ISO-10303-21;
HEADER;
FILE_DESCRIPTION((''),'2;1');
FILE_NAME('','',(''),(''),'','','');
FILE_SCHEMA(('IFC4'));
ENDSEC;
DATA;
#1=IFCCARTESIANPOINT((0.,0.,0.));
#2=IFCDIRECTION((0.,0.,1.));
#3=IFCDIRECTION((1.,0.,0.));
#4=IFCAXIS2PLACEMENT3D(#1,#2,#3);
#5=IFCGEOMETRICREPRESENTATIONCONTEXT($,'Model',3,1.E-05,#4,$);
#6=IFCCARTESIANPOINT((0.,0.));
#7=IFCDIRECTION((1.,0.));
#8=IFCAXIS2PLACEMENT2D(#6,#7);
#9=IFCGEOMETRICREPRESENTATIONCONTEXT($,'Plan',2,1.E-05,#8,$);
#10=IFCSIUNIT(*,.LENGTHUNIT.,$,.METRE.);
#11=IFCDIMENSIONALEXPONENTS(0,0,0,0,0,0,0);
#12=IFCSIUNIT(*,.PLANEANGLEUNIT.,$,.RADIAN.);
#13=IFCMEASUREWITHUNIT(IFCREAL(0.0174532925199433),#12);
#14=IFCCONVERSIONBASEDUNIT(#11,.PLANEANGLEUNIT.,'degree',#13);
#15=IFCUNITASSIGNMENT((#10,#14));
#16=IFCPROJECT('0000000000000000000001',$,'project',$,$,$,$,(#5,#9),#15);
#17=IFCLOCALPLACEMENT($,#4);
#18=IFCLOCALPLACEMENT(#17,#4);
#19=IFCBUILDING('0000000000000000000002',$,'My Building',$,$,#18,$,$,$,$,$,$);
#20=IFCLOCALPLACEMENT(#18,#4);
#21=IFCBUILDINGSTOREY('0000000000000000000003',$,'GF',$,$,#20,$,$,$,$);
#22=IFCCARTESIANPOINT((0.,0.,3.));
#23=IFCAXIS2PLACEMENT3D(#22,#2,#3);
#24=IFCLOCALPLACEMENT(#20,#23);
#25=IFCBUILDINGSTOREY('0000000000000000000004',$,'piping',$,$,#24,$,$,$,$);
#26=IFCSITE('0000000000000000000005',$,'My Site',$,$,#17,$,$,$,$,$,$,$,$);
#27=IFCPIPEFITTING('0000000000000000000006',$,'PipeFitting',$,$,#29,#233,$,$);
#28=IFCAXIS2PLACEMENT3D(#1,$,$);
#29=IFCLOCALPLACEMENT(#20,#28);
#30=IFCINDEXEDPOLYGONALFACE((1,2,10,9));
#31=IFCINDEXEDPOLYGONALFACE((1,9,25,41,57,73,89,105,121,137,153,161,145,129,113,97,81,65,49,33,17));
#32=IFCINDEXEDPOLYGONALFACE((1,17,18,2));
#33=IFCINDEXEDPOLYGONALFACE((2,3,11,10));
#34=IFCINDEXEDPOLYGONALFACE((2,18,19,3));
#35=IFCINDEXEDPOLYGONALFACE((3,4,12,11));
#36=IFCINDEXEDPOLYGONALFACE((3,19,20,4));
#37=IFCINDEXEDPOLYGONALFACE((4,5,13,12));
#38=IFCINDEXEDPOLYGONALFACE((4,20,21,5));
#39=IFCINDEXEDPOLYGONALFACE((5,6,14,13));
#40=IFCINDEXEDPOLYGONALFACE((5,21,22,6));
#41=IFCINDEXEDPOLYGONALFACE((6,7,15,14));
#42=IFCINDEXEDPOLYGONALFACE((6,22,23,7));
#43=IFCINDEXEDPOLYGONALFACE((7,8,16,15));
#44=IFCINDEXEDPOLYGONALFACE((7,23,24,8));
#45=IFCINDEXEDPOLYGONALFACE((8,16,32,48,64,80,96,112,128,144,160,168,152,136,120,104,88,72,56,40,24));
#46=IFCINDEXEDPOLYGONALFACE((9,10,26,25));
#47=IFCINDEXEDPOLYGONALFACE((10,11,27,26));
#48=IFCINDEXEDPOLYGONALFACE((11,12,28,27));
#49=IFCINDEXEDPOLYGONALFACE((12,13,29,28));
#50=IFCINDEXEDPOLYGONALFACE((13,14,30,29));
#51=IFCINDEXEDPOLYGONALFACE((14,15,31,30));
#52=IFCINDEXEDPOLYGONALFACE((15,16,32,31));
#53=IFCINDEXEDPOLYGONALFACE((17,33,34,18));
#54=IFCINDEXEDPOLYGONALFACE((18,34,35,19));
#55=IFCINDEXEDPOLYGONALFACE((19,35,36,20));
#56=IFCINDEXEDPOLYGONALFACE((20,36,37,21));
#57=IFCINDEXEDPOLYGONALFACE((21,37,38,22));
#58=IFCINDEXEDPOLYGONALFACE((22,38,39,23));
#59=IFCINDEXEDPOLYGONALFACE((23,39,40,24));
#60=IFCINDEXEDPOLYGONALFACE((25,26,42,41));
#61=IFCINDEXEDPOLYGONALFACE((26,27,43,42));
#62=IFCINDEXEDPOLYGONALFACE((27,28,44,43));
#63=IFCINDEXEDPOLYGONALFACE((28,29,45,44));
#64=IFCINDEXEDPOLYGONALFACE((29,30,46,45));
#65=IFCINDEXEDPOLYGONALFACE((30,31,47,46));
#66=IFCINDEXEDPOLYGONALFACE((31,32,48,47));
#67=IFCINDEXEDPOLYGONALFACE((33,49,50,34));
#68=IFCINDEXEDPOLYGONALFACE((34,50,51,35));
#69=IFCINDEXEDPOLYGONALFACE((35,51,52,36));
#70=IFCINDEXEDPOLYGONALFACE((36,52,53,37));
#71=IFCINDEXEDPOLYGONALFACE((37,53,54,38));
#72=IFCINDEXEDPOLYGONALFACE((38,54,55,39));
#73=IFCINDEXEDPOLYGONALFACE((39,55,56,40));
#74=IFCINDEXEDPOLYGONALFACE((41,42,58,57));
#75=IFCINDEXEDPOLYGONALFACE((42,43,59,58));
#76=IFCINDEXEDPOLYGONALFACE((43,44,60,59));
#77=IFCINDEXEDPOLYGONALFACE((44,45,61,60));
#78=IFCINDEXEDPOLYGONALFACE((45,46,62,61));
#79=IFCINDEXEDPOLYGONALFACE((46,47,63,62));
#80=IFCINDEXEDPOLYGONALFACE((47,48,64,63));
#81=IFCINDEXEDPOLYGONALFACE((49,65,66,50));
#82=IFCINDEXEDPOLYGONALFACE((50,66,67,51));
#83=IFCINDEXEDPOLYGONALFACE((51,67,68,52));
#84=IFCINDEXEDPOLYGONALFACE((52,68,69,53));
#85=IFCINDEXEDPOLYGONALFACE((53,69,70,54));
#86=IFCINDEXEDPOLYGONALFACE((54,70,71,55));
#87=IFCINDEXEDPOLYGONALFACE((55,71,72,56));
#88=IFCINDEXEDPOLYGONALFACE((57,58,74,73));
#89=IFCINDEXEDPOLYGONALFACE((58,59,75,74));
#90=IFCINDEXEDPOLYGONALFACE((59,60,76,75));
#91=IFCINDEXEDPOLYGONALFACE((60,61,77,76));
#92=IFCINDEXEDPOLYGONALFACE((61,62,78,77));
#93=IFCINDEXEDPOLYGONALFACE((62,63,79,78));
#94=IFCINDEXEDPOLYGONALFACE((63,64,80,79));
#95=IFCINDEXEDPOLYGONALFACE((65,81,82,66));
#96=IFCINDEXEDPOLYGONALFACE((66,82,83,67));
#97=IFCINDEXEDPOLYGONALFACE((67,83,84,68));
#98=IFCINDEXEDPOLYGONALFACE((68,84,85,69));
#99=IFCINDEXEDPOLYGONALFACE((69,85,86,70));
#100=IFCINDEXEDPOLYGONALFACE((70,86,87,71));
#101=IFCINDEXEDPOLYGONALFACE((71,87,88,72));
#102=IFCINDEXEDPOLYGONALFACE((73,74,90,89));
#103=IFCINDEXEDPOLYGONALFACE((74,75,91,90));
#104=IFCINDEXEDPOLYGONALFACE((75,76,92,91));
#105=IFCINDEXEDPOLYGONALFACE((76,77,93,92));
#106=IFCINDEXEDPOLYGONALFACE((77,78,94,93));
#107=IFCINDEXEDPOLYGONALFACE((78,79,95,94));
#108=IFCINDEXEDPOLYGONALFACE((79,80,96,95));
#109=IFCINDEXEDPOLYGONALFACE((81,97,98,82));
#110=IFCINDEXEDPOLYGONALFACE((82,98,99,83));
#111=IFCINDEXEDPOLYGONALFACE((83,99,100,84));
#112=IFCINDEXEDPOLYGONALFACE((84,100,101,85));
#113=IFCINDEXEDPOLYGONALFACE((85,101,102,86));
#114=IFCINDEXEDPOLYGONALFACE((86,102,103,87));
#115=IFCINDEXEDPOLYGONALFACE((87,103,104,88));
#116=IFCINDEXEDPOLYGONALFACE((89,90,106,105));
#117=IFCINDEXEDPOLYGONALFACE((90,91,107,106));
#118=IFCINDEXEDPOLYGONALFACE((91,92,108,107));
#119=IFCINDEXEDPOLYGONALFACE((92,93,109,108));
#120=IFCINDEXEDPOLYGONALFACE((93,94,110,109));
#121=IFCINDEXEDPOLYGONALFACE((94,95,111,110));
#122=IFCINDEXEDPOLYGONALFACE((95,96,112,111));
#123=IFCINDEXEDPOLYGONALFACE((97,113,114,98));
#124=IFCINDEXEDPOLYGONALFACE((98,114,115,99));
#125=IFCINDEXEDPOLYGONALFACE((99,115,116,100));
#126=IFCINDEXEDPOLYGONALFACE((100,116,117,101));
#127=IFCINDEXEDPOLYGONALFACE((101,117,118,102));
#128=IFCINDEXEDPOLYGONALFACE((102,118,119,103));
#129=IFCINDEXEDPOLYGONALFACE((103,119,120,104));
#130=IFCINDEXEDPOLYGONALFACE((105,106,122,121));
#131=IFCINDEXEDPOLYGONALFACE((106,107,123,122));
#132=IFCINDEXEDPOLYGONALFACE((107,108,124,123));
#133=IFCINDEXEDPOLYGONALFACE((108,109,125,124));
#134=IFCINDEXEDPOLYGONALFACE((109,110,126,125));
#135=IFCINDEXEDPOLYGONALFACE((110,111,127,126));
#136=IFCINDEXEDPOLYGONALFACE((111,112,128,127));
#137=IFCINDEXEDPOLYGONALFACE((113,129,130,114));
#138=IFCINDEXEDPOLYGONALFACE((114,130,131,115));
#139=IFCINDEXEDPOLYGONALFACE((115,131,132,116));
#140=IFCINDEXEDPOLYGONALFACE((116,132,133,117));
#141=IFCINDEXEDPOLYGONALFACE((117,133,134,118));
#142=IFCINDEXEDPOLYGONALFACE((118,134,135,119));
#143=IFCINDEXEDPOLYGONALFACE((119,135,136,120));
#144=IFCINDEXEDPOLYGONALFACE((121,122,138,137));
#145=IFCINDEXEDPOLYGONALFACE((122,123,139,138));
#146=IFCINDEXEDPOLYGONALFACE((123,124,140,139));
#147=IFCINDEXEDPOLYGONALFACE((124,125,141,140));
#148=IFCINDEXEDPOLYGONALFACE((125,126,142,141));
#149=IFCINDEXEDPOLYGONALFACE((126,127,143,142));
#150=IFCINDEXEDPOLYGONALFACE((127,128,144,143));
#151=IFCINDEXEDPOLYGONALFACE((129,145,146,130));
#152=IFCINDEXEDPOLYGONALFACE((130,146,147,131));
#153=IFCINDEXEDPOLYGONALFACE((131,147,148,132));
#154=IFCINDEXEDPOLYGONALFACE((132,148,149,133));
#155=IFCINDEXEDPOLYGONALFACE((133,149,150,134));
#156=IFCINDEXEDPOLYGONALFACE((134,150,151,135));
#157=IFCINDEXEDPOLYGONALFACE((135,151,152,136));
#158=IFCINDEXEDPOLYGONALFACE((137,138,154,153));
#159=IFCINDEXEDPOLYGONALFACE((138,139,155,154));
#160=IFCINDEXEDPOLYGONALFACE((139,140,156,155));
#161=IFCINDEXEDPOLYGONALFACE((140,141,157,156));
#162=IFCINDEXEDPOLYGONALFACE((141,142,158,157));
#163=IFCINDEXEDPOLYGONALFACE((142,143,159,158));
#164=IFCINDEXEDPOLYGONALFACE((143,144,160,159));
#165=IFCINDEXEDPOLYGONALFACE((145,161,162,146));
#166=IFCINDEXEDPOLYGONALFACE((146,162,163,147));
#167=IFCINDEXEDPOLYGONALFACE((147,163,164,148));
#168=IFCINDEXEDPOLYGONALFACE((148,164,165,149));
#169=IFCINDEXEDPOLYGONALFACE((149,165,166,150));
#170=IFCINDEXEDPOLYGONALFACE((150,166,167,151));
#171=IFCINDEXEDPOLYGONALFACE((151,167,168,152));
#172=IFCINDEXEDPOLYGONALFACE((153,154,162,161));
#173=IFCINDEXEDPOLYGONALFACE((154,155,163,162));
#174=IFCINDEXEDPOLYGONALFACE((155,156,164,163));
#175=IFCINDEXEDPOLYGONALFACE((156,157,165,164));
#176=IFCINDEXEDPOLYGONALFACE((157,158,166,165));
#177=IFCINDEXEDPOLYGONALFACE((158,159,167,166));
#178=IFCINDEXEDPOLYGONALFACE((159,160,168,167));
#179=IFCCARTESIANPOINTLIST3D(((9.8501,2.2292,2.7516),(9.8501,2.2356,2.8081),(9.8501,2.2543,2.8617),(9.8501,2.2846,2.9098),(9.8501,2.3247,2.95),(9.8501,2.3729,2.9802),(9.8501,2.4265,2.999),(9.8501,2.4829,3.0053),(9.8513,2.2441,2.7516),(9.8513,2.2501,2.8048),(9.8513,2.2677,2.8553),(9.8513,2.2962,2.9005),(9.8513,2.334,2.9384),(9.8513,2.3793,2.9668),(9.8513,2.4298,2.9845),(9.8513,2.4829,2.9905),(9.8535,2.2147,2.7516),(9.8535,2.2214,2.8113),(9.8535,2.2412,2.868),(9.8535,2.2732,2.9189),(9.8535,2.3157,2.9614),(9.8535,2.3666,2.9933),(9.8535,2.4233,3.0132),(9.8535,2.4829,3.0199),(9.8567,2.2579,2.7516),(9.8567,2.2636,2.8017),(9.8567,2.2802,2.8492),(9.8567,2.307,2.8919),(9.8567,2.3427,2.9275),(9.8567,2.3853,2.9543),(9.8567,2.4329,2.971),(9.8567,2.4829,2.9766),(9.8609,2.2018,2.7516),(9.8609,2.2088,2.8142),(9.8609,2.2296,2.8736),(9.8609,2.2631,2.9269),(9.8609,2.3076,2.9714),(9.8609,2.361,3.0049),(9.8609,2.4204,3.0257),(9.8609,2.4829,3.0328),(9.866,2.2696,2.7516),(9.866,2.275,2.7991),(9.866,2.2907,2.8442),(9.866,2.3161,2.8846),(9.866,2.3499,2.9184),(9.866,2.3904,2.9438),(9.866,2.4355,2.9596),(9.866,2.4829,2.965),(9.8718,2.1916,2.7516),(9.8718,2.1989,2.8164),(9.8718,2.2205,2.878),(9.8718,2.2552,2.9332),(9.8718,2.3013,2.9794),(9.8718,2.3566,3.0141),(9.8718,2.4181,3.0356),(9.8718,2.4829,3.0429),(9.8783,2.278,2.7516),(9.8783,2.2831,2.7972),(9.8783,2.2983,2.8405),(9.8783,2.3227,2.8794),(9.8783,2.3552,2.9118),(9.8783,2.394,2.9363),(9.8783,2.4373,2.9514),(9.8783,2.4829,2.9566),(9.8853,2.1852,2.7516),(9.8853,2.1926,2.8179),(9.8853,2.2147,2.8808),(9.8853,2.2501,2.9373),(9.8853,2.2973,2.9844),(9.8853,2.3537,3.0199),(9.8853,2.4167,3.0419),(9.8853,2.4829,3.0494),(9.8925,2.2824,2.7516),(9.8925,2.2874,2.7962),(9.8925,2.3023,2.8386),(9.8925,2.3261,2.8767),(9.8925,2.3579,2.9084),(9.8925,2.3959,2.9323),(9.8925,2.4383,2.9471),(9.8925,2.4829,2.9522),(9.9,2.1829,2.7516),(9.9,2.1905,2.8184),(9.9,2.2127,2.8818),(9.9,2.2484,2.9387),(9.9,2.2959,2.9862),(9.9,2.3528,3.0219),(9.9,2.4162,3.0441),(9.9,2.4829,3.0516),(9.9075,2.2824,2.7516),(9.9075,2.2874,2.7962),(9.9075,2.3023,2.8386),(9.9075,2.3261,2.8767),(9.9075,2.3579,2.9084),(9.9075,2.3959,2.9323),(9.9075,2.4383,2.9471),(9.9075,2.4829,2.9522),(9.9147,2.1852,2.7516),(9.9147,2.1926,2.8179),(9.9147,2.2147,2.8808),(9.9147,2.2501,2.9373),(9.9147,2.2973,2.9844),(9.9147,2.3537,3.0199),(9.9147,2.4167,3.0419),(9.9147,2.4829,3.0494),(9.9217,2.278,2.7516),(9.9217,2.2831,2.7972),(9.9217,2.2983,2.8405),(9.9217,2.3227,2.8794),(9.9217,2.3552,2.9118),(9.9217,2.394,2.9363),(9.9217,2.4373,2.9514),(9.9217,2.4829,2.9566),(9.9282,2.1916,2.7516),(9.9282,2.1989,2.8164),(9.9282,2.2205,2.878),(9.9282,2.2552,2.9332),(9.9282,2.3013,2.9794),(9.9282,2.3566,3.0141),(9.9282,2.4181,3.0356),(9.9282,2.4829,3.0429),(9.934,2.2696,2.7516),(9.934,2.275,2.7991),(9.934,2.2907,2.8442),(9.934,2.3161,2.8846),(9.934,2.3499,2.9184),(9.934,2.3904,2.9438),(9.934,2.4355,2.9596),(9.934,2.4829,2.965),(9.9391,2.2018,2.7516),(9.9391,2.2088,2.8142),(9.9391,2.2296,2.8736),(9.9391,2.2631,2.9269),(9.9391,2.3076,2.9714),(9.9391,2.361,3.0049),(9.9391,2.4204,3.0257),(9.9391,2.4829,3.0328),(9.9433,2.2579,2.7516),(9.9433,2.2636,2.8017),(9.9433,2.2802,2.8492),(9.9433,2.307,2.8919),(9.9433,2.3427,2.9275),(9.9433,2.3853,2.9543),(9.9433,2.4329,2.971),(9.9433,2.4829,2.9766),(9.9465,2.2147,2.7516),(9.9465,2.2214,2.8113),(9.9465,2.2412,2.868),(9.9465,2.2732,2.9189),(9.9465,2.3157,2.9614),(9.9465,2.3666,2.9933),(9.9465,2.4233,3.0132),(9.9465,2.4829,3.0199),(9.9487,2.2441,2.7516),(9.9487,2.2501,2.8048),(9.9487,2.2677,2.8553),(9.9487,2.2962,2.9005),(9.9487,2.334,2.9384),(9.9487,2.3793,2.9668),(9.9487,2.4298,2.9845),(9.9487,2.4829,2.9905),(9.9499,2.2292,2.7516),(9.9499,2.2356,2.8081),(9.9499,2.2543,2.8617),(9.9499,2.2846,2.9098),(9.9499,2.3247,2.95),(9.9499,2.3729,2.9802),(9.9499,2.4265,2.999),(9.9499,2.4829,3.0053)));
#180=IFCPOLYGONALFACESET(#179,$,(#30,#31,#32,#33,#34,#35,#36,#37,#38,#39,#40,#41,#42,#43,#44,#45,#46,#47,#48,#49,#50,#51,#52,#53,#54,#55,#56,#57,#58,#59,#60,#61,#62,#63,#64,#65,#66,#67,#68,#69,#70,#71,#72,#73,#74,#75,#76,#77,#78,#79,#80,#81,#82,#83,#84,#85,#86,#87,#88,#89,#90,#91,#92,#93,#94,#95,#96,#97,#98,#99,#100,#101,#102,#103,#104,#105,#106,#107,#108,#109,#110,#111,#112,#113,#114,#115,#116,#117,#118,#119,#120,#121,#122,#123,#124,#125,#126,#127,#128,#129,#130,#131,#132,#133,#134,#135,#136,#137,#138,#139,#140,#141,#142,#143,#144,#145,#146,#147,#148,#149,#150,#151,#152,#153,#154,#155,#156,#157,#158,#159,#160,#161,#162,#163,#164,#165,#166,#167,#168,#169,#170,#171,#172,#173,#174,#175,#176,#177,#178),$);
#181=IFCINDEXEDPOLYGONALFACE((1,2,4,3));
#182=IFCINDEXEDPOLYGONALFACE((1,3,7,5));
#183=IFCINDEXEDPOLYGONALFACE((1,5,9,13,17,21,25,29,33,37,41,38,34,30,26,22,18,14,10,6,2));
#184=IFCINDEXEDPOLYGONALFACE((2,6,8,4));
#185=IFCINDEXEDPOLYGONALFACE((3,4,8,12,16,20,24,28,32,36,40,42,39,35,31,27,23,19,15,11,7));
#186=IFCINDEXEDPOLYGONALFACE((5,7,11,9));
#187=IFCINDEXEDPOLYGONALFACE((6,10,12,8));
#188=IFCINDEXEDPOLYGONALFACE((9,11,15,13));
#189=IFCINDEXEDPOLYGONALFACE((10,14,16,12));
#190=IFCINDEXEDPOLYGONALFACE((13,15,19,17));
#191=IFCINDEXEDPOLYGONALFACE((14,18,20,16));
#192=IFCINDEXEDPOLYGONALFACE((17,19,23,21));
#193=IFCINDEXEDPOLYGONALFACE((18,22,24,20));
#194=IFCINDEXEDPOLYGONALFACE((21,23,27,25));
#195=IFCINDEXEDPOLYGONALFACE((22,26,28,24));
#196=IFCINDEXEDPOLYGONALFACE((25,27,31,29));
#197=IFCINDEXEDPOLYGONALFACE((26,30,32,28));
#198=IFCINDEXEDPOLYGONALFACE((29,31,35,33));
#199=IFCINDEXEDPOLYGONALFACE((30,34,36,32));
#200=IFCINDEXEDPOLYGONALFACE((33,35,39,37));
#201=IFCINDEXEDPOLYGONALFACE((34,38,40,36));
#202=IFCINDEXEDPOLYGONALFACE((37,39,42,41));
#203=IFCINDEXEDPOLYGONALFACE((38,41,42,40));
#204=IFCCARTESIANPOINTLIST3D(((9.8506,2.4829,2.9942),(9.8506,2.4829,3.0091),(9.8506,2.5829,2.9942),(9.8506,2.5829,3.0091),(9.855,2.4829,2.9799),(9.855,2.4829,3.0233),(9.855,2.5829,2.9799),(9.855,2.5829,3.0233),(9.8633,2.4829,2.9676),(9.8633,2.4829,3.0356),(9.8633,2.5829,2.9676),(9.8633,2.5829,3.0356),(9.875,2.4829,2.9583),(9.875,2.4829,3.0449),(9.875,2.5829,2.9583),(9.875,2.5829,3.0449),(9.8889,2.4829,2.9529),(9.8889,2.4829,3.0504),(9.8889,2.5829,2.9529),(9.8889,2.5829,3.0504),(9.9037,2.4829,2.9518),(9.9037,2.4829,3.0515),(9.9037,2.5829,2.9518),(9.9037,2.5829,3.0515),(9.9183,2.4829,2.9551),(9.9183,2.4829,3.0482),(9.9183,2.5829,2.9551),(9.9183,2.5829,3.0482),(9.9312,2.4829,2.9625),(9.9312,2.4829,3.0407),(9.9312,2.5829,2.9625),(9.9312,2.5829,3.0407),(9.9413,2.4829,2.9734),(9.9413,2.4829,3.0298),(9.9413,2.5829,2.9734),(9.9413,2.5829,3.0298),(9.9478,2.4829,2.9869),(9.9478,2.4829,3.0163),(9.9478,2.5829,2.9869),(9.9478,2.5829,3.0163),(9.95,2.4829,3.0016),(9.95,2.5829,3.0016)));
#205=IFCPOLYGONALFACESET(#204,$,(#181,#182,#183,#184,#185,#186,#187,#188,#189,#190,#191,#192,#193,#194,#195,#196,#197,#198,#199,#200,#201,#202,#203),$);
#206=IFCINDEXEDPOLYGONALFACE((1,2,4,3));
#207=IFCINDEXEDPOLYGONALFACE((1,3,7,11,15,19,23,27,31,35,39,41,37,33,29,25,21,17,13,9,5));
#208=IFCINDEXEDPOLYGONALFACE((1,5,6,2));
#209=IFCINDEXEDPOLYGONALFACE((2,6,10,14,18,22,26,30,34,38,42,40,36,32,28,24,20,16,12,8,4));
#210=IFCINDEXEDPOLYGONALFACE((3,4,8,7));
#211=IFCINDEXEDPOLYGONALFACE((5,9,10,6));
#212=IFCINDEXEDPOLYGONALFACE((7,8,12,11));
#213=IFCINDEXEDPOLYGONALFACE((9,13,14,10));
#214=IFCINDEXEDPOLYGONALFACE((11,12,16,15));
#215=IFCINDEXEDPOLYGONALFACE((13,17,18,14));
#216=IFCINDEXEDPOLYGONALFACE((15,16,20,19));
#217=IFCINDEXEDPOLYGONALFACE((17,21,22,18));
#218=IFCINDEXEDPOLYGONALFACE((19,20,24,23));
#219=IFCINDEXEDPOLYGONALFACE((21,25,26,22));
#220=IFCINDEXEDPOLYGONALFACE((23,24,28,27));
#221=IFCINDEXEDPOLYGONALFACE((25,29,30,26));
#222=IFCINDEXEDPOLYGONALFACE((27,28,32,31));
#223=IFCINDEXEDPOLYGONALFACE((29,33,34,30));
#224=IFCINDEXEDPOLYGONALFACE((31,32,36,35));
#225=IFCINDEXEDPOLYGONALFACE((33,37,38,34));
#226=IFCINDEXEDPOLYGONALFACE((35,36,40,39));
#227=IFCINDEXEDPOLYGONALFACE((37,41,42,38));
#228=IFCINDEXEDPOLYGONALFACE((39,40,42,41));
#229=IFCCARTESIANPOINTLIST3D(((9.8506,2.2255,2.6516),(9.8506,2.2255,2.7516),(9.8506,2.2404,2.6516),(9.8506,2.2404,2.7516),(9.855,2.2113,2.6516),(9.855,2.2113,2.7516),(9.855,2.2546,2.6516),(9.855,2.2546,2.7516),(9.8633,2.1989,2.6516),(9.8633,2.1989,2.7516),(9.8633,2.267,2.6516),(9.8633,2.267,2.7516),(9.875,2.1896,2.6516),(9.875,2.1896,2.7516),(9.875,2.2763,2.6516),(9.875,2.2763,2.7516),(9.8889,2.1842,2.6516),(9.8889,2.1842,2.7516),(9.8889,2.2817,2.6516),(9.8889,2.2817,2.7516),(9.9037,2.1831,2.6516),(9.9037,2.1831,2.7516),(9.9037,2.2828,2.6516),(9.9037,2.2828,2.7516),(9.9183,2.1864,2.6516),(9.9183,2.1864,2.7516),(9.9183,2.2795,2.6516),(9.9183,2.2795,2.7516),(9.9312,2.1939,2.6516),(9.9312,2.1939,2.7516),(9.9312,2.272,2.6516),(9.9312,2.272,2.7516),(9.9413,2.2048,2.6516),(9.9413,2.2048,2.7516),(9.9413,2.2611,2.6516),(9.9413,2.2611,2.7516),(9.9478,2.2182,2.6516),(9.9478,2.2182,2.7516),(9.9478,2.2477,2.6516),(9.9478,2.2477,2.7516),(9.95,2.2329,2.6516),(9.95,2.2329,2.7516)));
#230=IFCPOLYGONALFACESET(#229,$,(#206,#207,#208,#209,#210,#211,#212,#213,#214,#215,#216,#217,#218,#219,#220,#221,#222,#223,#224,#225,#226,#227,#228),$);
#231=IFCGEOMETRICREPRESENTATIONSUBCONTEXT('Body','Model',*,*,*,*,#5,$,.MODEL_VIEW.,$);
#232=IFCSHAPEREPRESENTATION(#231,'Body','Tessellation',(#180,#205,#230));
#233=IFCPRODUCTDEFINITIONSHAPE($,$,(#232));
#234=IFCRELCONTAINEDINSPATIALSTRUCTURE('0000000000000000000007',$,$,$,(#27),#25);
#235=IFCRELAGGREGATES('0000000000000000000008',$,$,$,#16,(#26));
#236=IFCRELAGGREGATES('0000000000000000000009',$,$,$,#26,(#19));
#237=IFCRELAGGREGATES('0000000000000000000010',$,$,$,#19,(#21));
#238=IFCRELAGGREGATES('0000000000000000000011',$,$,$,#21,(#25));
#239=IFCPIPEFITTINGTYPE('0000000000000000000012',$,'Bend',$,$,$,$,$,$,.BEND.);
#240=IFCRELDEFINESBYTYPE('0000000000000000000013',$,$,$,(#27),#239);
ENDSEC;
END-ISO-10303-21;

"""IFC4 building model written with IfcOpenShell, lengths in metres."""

from ifc_helpers import new_model, entity, si_unit, converted_unit, frame, origin_with_axes, origin_2d_with_axis, place, context, subcontext, project, spatial, circle, extrude, source, transform, mapped, type_object, type_shapes, element, save


model = new_model("IFC4")

# Units and contexts
model_context = context("Model", 3, precision=1e-05, world=origin_with_axes())
plan_context = context("Plan", 2, precision=1e-05, world=origin_2d_with_axis())
body_context = subcontext(model_context, "Body", "Model", "MODEL_VIEW")
ifc_project = project(units=[si_unit("LENGTHUNIT", "METRE"), converted_unit("PLANEANGLEUNIT", "degree", entity("IfcReal", 0.0174532925199433), si_unit("PLANEANGLEUNIT", "RADIAN"), dimensions=[0, 0, 0, 0, 0, 0, 0])], contexts=[model_context, plan_context])

# Site, building, storeys
site_placement = place(None, origin_with_axes())
site = spatial("IfcSite", under=ifc_project, at=site_placement, Name="My Site")
building_placement = place(site_placement, origin_with_axes())
building = spatial("IfcBuilding", under=site, at=building_placement, Name="My Building")
storey_1_placement = place(building_placement, origin_with_axes())
storey_1 = spatial("IfcBuildingStorey", under=building, at=storey_1_placement, Name="GF")
storey_2_placement = place(storey_1_placement, frame((0.0, 0.0, 3.0), z_axis=(0.0, 0.0, 1.0), x_axis=(1.0, 0.0, 0.0)))
storey_2 = spatial("IfcBuildingStorey", under=storey_1, at=storey_2_placement, Name="piping")

# Pipe fitting
pipe_fitting_type = type_object("IfcPipeFittingType", Name="Bend", PredefinedType="BEND")
shared_shape = source(origin_with_axes(), body_context, "Body", "SolidModel", [
    entity("IfcSweptDiskSolid", entity("IfcIndexedPolyCurve", entity("IfcCartesianPointList3D", [[0.0, 0.0, -0.1], [0.0, 0.0732, -0.2768], [0.0, 0.25, -0.35]]), [entity("IfcArcIndex", [1, 2, 3])]), 0.05),
    extrude(circle(Radius=0.05), origin_with_axes(), (0.0, 0.0, -1.0), 0.1),
    extrude(circle(Radius=0.05), frame((0.0, 0.25, -0.35), z_axis=(0.0, 1.0, 0.0), x_axis=(1.0, 0.0, 0.0)), (0.0, 0.0, 1.0), 0.1),
])
type_shapes(pipe_fitting_type, [shared_shape])
for number, where, z_axis, x_axis, name in (
    (1, (9.9, 2.5829, 0.0016), (0.0, 1.0, 0.0), (1.0, 0.0, 0.0), "PipeFitting"),
):
    element("IfcPipeFitting", number, at=place(storey_2_placement, frame(where, z_axis=z_axis, x_axis=x_axis)), inside=storey_2, type_object=pipe_fitting_type, Name=name, context=body_context, shape_type="MappedRepresentation", body=[
        mapped(shared_shape, transform((0.0, 0.0, 0.0), x_axis=(1.0, 0.0, 0.0), y_axis=(0.0, 1.0, 0.0), z_axis=(0.0, 0.0, 1.0), scale=1.0)),
    ])

save(model, "model.ifc")
